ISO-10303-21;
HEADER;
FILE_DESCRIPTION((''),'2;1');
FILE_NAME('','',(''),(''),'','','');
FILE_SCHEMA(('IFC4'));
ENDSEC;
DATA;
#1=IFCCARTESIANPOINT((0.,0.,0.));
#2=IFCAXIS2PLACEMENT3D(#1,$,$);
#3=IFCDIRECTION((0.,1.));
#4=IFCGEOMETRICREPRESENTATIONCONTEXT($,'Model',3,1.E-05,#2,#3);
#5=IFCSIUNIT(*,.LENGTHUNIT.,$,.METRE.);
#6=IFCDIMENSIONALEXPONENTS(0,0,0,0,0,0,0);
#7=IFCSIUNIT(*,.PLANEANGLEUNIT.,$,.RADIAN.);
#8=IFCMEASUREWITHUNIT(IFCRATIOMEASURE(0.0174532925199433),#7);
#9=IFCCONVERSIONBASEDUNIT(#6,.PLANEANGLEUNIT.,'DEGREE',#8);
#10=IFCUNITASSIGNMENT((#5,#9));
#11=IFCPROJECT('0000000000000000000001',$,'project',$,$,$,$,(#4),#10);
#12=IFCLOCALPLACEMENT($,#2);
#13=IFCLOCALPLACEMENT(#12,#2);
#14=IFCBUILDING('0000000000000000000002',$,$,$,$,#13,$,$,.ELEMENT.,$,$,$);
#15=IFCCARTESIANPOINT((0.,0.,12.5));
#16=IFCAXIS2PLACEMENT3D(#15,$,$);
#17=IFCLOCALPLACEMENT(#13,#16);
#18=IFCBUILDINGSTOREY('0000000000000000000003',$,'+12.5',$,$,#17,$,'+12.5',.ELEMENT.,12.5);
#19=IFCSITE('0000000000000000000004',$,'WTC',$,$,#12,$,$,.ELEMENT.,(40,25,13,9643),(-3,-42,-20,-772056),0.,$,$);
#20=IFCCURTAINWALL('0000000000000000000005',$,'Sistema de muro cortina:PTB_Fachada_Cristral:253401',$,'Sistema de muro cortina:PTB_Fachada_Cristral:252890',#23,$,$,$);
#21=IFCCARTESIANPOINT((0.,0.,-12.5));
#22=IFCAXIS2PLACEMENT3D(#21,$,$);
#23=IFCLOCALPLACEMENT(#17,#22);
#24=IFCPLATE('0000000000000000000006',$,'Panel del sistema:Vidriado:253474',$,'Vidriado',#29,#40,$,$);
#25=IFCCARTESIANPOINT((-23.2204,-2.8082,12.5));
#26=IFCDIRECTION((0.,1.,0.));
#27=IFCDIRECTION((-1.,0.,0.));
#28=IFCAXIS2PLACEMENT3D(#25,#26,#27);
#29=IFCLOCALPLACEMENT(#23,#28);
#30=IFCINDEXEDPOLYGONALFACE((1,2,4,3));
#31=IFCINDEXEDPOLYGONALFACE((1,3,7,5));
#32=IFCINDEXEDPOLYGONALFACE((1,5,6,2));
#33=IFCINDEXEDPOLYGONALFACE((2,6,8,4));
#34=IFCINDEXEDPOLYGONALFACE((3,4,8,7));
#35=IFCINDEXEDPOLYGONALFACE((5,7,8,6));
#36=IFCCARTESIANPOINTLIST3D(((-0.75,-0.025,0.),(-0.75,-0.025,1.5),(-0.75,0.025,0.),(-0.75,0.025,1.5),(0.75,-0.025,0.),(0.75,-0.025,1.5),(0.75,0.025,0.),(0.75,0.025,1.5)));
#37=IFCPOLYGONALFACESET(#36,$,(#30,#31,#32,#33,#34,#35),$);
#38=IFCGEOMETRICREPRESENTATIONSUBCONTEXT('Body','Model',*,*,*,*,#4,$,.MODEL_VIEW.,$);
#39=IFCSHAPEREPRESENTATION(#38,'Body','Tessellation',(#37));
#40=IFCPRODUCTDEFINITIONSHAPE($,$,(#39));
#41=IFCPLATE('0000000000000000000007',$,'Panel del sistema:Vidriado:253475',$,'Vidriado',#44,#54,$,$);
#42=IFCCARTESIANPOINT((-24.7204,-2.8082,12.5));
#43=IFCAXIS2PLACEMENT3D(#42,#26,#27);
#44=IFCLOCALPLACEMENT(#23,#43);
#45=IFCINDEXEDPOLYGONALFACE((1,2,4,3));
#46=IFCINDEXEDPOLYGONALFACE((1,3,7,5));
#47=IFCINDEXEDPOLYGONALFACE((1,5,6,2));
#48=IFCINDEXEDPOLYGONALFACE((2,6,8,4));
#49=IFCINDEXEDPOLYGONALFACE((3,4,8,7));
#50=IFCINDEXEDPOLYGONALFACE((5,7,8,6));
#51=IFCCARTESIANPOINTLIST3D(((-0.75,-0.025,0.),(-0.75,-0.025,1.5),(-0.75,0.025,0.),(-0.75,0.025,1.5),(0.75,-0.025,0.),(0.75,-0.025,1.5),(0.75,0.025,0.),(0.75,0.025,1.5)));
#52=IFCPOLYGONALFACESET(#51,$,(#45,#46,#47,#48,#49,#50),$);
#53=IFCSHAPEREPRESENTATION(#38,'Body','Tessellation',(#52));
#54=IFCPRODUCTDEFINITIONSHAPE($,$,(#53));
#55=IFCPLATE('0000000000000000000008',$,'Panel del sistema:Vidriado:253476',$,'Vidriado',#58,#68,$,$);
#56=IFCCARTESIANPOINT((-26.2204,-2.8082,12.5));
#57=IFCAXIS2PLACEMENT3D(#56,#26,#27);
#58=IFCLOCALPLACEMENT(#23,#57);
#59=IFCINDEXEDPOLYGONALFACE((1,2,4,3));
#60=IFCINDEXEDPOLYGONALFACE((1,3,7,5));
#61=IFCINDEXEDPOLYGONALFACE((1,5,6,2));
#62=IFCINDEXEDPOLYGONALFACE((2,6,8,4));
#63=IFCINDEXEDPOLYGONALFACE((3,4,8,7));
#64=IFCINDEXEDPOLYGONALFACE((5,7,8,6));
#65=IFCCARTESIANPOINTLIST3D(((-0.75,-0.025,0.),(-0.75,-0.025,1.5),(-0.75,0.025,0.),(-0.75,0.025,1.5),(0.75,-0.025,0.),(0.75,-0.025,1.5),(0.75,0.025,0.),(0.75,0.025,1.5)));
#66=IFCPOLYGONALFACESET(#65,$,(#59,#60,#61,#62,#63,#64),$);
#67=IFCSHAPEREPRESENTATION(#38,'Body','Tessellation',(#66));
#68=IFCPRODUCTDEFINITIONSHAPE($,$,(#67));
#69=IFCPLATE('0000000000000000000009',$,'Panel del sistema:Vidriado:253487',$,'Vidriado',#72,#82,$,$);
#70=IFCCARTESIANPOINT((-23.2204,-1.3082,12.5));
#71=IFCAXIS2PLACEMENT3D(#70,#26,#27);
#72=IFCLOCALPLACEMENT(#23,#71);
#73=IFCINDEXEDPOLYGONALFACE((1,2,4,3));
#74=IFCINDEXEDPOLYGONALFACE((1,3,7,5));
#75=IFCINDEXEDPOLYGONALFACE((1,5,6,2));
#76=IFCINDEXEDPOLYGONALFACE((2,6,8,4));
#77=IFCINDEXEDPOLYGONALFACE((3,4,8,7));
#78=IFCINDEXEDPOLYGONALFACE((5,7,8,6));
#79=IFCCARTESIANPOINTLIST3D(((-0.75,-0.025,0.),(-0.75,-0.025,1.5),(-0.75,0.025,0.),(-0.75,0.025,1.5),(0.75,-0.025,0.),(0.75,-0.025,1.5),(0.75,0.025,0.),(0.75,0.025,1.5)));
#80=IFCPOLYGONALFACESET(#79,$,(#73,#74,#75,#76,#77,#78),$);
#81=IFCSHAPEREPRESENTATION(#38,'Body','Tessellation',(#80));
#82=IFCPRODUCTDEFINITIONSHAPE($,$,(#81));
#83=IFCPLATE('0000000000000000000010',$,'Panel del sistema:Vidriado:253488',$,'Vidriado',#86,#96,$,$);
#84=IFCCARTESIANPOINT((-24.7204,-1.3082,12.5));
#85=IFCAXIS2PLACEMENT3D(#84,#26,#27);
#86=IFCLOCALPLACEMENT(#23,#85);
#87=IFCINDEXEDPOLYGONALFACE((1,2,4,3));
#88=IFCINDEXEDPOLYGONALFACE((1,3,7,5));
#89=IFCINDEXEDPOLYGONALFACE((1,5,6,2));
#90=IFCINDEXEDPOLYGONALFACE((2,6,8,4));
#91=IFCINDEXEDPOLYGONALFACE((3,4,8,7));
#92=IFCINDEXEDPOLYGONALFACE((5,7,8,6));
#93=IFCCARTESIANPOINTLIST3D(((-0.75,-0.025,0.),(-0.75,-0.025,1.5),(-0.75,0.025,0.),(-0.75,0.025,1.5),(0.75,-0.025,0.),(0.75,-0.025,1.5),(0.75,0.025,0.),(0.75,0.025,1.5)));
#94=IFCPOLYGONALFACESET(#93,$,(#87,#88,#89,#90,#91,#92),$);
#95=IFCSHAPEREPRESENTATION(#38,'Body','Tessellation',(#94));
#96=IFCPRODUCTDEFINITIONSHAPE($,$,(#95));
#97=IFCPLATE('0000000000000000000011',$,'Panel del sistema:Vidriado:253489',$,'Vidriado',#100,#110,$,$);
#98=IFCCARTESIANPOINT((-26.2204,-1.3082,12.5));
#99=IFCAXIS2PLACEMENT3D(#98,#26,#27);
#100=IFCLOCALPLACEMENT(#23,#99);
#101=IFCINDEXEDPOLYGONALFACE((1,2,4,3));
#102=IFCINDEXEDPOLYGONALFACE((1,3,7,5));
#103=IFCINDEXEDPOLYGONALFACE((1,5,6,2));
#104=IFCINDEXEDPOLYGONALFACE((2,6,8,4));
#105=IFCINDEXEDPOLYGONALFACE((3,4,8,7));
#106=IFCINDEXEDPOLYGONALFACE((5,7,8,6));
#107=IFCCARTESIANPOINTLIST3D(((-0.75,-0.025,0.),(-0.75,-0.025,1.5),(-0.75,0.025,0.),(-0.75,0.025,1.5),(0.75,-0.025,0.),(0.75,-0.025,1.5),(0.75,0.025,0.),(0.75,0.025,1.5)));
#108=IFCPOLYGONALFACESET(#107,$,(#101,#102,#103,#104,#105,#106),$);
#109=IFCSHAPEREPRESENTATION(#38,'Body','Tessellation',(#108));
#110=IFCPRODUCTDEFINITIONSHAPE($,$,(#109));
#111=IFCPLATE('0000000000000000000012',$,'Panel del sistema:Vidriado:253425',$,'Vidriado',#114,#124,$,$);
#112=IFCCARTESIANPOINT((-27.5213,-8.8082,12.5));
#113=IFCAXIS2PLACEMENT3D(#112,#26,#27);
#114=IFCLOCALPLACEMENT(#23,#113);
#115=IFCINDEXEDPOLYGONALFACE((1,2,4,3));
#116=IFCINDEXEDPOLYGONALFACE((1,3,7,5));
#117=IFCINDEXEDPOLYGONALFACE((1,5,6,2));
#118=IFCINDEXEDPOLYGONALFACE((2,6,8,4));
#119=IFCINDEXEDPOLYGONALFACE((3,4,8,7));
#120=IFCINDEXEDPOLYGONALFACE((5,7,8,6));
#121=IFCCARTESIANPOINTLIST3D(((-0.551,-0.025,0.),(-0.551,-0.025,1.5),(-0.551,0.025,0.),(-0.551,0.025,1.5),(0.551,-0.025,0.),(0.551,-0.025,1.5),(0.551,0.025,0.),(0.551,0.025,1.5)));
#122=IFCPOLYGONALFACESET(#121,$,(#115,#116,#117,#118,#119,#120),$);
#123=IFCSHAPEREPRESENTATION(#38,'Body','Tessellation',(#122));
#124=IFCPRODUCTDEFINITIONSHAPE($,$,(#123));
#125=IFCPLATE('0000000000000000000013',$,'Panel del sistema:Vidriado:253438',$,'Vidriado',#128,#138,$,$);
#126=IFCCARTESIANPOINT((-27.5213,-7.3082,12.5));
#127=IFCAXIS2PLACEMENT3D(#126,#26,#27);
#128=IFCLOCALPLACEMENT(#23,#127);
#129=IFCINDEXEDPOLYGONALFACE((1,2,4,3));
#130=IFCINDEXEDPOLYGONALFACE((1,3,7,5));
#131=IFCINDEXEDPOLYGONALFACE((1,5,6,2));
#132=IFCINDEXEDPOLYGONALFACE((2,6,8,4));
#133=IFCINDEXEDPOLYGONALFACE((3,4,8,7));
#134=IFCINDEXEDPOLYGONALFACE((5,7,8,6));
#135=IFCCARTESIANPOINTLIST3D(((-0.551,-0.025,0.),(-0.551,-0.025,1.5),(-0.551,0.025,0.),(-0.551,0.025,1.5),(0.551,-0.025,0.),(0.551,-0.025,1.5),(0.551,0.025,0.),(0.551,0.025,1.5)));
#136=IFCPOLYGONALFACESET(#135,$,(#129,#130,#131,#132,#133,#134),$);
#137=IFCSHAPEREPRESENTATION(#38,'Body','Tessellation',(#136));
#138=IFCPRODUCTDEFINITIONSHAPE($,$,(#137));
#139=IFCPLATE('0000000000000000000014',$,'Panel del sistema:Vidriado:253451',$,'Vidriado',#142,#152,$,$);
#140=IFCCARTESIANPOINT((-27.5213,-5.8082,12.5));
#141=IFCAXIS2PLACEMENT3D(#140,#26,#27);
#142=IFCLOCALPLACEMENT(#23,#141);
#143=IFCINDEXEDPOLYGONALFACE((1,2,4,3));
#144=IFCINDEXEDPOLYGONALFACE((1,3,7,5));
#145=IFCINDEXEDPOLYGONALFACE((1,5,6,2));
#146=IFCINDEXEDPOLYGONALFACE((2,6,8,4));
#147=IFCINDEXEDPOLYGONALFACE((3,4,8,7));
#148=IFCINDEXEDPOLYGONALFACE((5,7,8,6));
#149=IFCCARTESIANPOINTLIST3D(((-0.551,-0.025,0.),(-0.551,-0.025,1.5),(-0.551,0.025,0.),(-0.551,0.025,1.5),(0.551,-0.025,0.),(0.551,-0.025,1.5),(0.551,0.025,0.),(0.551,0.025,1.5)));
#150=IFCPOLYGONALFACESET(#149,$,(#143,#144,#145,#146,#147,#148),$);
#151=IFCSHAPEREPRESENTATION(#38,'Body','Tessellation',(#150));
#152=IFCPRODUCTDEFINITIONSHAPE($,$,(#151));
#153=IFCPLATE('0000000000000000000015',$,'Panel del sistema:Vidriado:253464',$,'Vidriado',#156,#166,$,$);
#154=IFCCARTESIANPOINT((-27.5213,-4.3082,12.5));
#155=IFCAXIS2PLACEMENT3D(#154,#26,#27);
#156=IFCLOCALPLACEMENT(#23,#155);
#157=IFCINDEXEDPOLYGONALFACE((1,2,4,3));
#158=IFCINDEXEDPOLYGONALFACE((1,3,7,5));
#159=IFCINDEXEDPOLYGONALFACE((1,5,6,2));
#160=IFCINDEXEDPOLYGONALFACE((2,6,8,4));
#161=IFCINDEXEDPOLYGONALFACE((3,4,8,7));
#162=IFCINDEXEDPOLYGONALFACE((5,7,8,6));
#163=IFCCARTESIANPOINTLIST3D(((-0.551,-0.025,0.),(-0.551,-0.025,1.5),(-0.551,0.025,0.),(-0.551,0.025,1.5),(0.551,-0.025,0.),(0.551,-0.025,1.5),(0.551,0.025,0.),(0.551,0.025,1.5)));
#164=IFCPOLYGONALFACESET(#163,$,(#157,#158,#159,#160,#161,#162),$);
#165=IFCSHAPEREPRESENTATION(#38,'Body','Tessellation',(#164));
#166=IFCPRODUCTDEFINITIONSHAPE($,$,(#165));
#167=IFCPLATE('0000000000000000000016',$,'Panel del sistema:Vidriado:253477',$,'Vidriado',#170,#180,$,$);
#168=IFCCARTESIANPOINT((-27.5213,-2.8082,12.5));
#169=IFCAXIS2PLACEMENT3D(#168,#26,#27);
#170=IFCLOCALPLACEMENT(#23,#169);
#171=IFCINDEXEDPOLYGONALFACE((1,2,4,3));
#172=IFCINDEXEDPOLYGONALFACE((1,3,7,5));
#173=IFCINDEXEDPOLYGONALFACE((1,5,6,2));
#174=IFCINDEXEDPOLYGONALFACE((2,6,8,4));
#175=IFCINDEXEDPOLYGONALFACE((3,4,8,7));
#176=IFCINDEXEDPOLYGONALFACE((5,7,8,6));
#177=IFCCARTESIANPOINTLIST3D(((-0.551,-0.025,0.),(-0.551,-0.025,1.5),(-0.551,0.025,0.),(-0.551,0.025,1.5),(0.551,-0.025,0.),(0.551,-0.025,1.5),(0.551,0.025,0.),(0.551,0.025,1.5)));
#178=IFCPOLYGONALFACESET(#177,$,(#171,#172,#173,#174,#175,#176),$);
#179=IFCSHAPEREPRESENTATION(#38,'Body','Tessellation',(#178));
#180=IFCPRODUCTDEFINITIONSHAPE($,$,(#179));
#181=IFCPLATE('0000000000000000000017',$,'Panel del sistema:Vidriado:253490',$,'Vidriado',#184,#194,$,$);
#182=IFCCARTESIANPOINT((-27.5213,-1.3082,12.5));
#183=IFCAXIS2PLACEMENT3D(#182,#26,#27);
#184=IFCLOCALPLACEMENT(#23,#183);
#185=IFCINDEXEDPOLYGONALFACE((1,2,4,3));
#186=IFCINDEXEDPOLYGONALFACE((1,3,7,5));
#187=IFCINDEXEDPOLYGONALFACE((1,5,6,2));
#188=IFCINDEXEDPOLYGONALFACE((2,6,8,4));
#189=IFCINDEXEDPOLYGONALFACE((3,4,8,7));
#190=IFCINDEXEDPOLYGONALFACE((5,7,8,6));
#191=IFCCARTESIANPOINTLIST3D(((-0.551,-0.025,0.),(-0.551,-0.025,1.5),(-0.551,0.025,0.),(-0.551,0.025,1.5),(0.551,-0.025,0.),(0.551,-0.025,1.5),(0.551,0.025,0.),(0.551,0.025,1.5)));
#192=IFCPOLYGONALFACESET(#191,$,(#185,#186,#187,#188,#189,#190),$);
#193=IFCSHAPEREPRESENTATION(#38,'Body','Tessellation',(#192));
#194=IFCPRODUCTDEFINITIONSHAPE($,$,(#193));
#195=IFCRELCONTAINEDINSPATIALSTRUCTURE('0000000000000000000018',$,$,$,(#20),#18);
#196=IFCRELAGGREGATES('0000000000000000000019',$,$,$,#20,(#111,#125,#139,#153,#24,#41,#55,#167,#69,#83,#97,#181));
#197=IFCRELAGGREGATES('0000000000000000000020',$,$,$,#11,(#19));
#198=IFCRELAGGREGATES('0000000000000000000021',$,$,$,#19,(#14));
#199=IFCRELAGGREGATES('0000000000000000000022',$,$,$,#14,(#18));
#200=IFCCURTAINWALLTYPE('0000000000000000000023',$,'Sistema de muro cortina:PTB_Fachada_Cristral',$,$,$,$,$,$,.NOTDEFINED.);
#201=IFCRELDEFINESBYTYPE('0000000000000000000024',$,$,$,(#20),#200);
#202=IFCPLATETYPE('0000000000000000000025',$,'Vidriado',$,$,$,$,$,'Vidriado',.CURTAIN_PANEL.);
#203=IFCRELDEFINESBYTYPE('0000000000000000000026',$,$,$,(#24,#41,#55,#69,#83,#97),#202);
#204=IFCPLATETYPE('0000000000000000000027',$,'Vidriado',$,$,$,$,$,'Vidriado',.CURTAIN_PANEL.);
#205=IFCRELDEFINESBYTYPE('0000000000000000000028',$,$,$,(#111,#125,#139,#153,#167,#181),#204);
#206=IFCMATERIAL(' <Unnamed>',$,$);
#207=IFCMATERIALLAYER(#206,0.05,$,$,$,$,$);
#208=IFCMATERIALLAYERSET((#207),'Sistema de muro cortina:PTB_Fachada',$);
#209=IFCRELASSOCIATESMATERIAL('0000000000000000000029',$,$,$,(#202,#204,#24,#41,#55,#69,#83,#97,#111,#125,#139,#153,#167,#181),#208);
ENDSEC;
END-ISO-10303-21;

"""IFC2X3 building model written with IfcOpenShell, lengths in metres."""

from ifc_helpers import new_model, entity, si_unit, converted_unit, direction, frame, origin, origin_2d_with_axis, place, context, subcontext, project, spatial, rectangle, extrude, source, transform, mapped, material, layer, layer_set, layer_usage, type_object, type_shapes, element, aggregate, save


model = new_model("IFC2X3")

# Units and contexts
model_context = context("Model", 3, precision=1e-05, world=origin(), true_north=direction((0.0, 1.0)))
body_context = subcontext(model_context, "Body", "Model", "MODEL_VIEW")
ifc_project = project(units=[si_unit("LENGTHUNIT", "METRE"), converted_unit("PLANEANGLEUNIT", "DEGREE", entity("IfcRatioMeasure", 0.0174532925199433), si_unit("PLANEANGLEUNIT", "RADIAN"), dimensions=[0, 0, 0, 0, 0, 0, 0])], contexts=[model_context])

# Site, building, storey
site_placement = place(None, origin())
site = spatial("IfcSite", under=ifc_project, at=site_placement, Name="WTC", CompositionType="ELEMENT", RefLatitude=(40, 25, 13, 9643), RefLongitude=(-3, -42, -20, -772056), RefElevation=0.0)
building_placement = place(site_placement, origin())
building = spatial("IfcBuilding", under=site, at=building_placement, CompositionType="ELEMENT")
storey_placement = place(building_placement, frame((0.0, 0.0, 12.5)))
storey = spatial("IfcBuildingStorey", under=building, at=storey_placement, Name="+12.5", LongName="+12.5", CompositionType="ELEMENT", Elevation=12.5)

# Curtain wall, plates
curtain_wall_type = type_object("IfcCurtainWallType", Name="Sistema de muro cortina:PTB_Fachada_Cristral", PredefinedType="NOTDEFINED")
curtain_wall_placement = place(storey_placement, frame((0.0, 0.0, -12.5)))
curtain_wall = element("IfcCurtainWall", 1, at=curtain_wall_placement, inside=storey, type_object=curtain_wall_type, Name="Sistema de muro cortina:PTB_Fachada_Cristral:253401", ObjectType="Sistema de muro cortina:PTB_Fachada_Cristral:252890")
ifc_material = material(Name=" <Unnamed>")
ifc_layer = layer(ifc_material, 0.05)
ifc_layer_set = layer_set([ifc_layer], Name="Sistema de muro cortina:PTB_Fachada")
plate_type_1 = type_object("IfcPlateType", Name="Vidriado", ElementType="Vidriado", PredefinedType="CURTAIN_PANEL", material=ifc_layer_set)
shared_shape_1 = source(origin(), body_context, "Body", "SweptSolid", [
    extrude(rectangle(XDim=0.05, YDim=1.5, at=origin_2d_with_axis()), frame((0.0, 0.0, 0.0), z_axis=(0.0, 0.0, 1.0), x_axis=(0.0, 1.0, 0.0)), (0.0, 0.0, 1.0), 1.5),
])
type_shapes(plate_type_1, [shared_shape_1])
ifc_layer_usage_1 = layer_usage(ifc_layer_set, "AXIS3", "POSITIVE", 0.0)
plate_1_placement = place(curtain_wall_placement, frame((-23.2204, -2.8082, 12.5), z_axis=(0.0, 1.0, 0.0), x_axis=(-1.0, 0.0, 0.0)))
plate_1 = element("IfcPlate", 2, at=plate_1_placement, type_object=plate_type_1, material=ifc_layer_usage_1, Name="Panel del sistema:Vidriado:253474", ObjectType="Vidriado", context=body_context, shape_type="MappedRepresentation", body=[
    mapped(shared_shape_1, transform((0.0, 0.0, 0.0), scale=1.0)),
])
ifc_layer_usage_2 = layer_usage(ifc_layer_set, "AXIS3", "POSITIVE", 0.0)
plate_2_placement = place(curtain_wall_placement, frame((-24.7204, -2.8082, 12.5), z_axis=(0.0, 1.0, 0.0), x_axis=(-1.0, 0.0, 0.0)))
plate_2 = element("IfcPlate", 3, at=plate_2_placement, type_object=plate_type_1, material=ifc_layer_usage_2, Name="Panel del sistema:Vidriado:253475", ObjectType="Vidriado", context=body_context, shape_type="MappedRepresentation", body=[
    mapped(shared_shape_1, transform((0.0, 0.0, 0.0), scale=1.0)),
])
ifc_layer_usage_3 = layer_usage(ifc_layer_set, "AXIS3", "POSITIVE", 0.0)
plate_3_placement = place(curtain_wall_placement, frame((-26.2204, -2.8082, 12.5), z_axis=(0.0, 1.0, 0.0), x_axis=(-1.0, 0.0, 0.0)))
plate_3 = element("IfcPlate", 4, at=plate_3_placement, type_object=plate_type_1, material=ifc_layer_usage_3, Name="Panel del sistema:Vidriado:253476", ObjectType="Vidriado", context=body_context, shape_type="MappedRepresentation", body=[
    mapped(shared_shape_1, transform((0.0, 0.0, 0.0), scale=1.0)),
])
ifc_layer_usage_4 = layer_usage(ifc_layer_set, "AXIS3", "POSITIVE", 0.0)
plate_4_placement = place(curtain_wall_placement, frame((-23.2204, -1.3082, 12.5), z_axis=(0.0, 1.0, 0.0), x_axis=(-1.0, 0.0, 0.0)))
plate_4 = element("IfcPlate", 5, at=plate_4_placement, type_object=plate_type_1, material=ifc_layer_usage_4, Name="Panel del sistema:Vidriado:253487", ObjectType="Vidriado", context=body_context, shape_type="MappedRepresentation", body=[
    mapped(shared_shape_1, transform((0.0, 0.0, 0.0), scale=1.0)),
])
ifc_layer_usage_5 = layer_usage(ifc_layer_set, "AXIS3", "POSITIVE", 0.0)
plate_5_placement = place(curtain_wall_placement, frame((-24.7204, -1.3082, 12.5), z_axis=(0.0, 1.0, 0.0), x_axis=(-1.0, 0.0, 0.0)))
plate_5 = element("IfcPlate", 6, at=plate_5_placement, type_object=plate_type_1, material=ifc_layer_usage_5, Name="Panel del sistema:Vidriado:253488", ObjectType="Vidriado", context=body_context, shape_type="MappedRepresentation", body=[
    mapped(shared_shape_1, transform((0.0, 0.0, 0.0), scale=1.0)),
])
ifc_layer_usage_6 = layer_usage(ifc_layer_set, "AXIS3", "POSITIVE", 0.0)
plate_6_placement = place(curtain_wall_placement, frame((-26.2204, -1.3082, 12.5), z_axis=(0.0, 1.0, 0.0), x_axis=(-1.0, 0.0, 0.0)))
plate_6 = element("IfcPlate", 7, at=plate_6_placement, type_object=plate_type_1, material=ifc_layer_usage_6, Name="Panel del sistema:Vidriado:253489", ObjectType="Vidriado", context=body_context, shape_type="MappedRepresentation", body=[
    mapped(shared_shape_1, transform((0.0, 0.0, 0.0), scale=1.0)),
])
ifc_layer_usage_7 = layer_usage(ifc_layer_set, "AXIS3", "POSITIVE", 0.0)
plate_type_2 = type_object("IfcPlateType", Name="Vidriado", ElementType="Vidriado", PredefinedType="CURTAIN_PANEL", material=ifc_layer_set)
shared_shape_2 = source(origin(), body_context, "Body", "SweptSolid", [
    extrude(rectangle(XDim=0.05, YDim=1.1019, at=origin_2d_with_axis()), frame((0.0, 0.0, 0.0), z_axis=(0.0, 0.0, 1.0), x_axis=(0.0, 1.0, 0.0)), (0.0, 0.0, 1.0), 1.5),
])
type_shapes(plate_type_2, [shared_shape_2])
plate_7_placement = place(curtain_wall_placement, frame((-27.5213, -8.8082, 12.5), z_axis=(0.0, 1.0, 0.0), x_axis=(-1.0, 0.0, 0.0)))
plate_7 = element("IfcPlate", 8, at=plate_7_placement, type_object=plate_type_2, material=ifc_layer_usage_7, Name="Panel del sistema:Vidriado:253425", ObjectType="Vidriado", context=body_context, shape_type="MappedRepresentation", body=[
    mapped(shared_shape_2, transform((0.0, 0.0, 0.0), scale=1.0)),
])
ifc_layer_usage_8 = layer_usage(ifc_layer_set, "AXIS3", "POSITIVE", 0.0)
plate_8_placement = place(curtain_wall_placement, frame((-27.5213, -7.3082, 12.5), z_axis=(0.0, 1.0, 0.0), x_axis=(-1.0, 0.0, 0.0)))
plate_8 = element("IfcPlate", 9, at=plate_8_placement, type_object=plate_type_2, material=ifc_layer_usage_8, Name="Panel del sistema:Vidriado:253438", ObjectType="Vidriado", context=body_context, shape_type="MappedRepresentation", body=[
    mapped(shared_shape_2, transform((0.0, 0.0, 0.0), scale=1.0)),
])
ifc_layer_usage_9 = layer_usage(ifc_layer_set, "AXIS3", "POSITIVE", 0.0)
plate_9_placement = place(curtain_wall_placement, frame((-27.5213, -5.8082, 12.5), z_axis=(0.0, 1.0, 0.0), x_axis=(-1.0, 0.0, 0.0)))
plate_9 = element("IfcPlate", 10, at=plate_9_placement, type_object=plate_type_2, material=ifc_layer_usage_9, Name="Panel del sistema:Vidriado:253451", ObjectType="Vidriado", context=body_context, shape_type="MappedRepresentation", body=[
    mapped(shared_shape_2, transform((0.0, 0.0, 0.0), scale=1.0)),
])
ifc_layer_usage_10 = layer_usage(ifc_layer_set, "AXIS3", "POSITIVE", 0.0)
plate_10_placement = place(curtain_wall_placement, frame((-27.5213, -4.3082, 12.5), z_axis=(0.0, 1.0, 0.0), x_axis=(-1.0, 0.0, 0.0)))
plate_10 = element("IfcPlate", 11, at=plate_10_placement, type_object=plate_type_2, material=ifc_layer_usage_10, Name="Panel del sistema:Vidriado:253464", ObjectType="Vidriado", context=body_context, shape_type="MappedRepresentation", body=[
    mapped(shared_shape_2, transform((0.0, 0.0, 0.0), scale=1.0)),
])
ifc_layer_usage_11 = layer_usage(ifc_layer_set, "AXIS3", "POSITIVE", 0.0)
plate_11_placement = place(curtain_wall_placement, frame((-27.5213, -2.8082, 12.5), z_axis=(0.0, 1.0, 0.0), x_axis=(-1.0, 0.0, 0.0)))
plate_11 = element("IfcPlate", 12, at=plate_11_placement, type_object=plate_type_2, material=ifc_layer_usage_11, Name="Panel del sistema:Vidriado:253477", ObjectType="Vidriado", context=body_context, shape_type="MappedRepresentation", body=[
    mapped(shared_shape_2, transform((0.0, 0.0, 0.0), scale=1.0)),
])
ifc_layer_usage_12 = layer_usage(ifc_layer_set, "AXIS3", "POSITIVE", 0.0)
plate_12_placement = place(curtain_wall_placement, frame((-27.5213, -1.3082, 12.5), z_axis=(0.0, 1.0, 0.0), x_axis=(-1.0, 0.0, 0.0)))
plate_12 = element("IfcPlate", 13, at=plate_12_placement, type_object=plate_type_2, material=ifc_layer_usage_12, Name="Panel del sistema:Vidriado:253490", ObjectType="Vidriado", context=body_context, shape_type="MappedRepresentation", body=[
    mapped(shared_shape_2, transform((0.0, 0.0, 0.0), scale=1.0)),
])
aggregate(curtain_wall, [plate_7, plate_8, plate_9, plate_10, plate_1, plate_2, plate_3, plate_11, plate_4, plate_5, plate_6, plate_12])

save(model, "model.ifc")
